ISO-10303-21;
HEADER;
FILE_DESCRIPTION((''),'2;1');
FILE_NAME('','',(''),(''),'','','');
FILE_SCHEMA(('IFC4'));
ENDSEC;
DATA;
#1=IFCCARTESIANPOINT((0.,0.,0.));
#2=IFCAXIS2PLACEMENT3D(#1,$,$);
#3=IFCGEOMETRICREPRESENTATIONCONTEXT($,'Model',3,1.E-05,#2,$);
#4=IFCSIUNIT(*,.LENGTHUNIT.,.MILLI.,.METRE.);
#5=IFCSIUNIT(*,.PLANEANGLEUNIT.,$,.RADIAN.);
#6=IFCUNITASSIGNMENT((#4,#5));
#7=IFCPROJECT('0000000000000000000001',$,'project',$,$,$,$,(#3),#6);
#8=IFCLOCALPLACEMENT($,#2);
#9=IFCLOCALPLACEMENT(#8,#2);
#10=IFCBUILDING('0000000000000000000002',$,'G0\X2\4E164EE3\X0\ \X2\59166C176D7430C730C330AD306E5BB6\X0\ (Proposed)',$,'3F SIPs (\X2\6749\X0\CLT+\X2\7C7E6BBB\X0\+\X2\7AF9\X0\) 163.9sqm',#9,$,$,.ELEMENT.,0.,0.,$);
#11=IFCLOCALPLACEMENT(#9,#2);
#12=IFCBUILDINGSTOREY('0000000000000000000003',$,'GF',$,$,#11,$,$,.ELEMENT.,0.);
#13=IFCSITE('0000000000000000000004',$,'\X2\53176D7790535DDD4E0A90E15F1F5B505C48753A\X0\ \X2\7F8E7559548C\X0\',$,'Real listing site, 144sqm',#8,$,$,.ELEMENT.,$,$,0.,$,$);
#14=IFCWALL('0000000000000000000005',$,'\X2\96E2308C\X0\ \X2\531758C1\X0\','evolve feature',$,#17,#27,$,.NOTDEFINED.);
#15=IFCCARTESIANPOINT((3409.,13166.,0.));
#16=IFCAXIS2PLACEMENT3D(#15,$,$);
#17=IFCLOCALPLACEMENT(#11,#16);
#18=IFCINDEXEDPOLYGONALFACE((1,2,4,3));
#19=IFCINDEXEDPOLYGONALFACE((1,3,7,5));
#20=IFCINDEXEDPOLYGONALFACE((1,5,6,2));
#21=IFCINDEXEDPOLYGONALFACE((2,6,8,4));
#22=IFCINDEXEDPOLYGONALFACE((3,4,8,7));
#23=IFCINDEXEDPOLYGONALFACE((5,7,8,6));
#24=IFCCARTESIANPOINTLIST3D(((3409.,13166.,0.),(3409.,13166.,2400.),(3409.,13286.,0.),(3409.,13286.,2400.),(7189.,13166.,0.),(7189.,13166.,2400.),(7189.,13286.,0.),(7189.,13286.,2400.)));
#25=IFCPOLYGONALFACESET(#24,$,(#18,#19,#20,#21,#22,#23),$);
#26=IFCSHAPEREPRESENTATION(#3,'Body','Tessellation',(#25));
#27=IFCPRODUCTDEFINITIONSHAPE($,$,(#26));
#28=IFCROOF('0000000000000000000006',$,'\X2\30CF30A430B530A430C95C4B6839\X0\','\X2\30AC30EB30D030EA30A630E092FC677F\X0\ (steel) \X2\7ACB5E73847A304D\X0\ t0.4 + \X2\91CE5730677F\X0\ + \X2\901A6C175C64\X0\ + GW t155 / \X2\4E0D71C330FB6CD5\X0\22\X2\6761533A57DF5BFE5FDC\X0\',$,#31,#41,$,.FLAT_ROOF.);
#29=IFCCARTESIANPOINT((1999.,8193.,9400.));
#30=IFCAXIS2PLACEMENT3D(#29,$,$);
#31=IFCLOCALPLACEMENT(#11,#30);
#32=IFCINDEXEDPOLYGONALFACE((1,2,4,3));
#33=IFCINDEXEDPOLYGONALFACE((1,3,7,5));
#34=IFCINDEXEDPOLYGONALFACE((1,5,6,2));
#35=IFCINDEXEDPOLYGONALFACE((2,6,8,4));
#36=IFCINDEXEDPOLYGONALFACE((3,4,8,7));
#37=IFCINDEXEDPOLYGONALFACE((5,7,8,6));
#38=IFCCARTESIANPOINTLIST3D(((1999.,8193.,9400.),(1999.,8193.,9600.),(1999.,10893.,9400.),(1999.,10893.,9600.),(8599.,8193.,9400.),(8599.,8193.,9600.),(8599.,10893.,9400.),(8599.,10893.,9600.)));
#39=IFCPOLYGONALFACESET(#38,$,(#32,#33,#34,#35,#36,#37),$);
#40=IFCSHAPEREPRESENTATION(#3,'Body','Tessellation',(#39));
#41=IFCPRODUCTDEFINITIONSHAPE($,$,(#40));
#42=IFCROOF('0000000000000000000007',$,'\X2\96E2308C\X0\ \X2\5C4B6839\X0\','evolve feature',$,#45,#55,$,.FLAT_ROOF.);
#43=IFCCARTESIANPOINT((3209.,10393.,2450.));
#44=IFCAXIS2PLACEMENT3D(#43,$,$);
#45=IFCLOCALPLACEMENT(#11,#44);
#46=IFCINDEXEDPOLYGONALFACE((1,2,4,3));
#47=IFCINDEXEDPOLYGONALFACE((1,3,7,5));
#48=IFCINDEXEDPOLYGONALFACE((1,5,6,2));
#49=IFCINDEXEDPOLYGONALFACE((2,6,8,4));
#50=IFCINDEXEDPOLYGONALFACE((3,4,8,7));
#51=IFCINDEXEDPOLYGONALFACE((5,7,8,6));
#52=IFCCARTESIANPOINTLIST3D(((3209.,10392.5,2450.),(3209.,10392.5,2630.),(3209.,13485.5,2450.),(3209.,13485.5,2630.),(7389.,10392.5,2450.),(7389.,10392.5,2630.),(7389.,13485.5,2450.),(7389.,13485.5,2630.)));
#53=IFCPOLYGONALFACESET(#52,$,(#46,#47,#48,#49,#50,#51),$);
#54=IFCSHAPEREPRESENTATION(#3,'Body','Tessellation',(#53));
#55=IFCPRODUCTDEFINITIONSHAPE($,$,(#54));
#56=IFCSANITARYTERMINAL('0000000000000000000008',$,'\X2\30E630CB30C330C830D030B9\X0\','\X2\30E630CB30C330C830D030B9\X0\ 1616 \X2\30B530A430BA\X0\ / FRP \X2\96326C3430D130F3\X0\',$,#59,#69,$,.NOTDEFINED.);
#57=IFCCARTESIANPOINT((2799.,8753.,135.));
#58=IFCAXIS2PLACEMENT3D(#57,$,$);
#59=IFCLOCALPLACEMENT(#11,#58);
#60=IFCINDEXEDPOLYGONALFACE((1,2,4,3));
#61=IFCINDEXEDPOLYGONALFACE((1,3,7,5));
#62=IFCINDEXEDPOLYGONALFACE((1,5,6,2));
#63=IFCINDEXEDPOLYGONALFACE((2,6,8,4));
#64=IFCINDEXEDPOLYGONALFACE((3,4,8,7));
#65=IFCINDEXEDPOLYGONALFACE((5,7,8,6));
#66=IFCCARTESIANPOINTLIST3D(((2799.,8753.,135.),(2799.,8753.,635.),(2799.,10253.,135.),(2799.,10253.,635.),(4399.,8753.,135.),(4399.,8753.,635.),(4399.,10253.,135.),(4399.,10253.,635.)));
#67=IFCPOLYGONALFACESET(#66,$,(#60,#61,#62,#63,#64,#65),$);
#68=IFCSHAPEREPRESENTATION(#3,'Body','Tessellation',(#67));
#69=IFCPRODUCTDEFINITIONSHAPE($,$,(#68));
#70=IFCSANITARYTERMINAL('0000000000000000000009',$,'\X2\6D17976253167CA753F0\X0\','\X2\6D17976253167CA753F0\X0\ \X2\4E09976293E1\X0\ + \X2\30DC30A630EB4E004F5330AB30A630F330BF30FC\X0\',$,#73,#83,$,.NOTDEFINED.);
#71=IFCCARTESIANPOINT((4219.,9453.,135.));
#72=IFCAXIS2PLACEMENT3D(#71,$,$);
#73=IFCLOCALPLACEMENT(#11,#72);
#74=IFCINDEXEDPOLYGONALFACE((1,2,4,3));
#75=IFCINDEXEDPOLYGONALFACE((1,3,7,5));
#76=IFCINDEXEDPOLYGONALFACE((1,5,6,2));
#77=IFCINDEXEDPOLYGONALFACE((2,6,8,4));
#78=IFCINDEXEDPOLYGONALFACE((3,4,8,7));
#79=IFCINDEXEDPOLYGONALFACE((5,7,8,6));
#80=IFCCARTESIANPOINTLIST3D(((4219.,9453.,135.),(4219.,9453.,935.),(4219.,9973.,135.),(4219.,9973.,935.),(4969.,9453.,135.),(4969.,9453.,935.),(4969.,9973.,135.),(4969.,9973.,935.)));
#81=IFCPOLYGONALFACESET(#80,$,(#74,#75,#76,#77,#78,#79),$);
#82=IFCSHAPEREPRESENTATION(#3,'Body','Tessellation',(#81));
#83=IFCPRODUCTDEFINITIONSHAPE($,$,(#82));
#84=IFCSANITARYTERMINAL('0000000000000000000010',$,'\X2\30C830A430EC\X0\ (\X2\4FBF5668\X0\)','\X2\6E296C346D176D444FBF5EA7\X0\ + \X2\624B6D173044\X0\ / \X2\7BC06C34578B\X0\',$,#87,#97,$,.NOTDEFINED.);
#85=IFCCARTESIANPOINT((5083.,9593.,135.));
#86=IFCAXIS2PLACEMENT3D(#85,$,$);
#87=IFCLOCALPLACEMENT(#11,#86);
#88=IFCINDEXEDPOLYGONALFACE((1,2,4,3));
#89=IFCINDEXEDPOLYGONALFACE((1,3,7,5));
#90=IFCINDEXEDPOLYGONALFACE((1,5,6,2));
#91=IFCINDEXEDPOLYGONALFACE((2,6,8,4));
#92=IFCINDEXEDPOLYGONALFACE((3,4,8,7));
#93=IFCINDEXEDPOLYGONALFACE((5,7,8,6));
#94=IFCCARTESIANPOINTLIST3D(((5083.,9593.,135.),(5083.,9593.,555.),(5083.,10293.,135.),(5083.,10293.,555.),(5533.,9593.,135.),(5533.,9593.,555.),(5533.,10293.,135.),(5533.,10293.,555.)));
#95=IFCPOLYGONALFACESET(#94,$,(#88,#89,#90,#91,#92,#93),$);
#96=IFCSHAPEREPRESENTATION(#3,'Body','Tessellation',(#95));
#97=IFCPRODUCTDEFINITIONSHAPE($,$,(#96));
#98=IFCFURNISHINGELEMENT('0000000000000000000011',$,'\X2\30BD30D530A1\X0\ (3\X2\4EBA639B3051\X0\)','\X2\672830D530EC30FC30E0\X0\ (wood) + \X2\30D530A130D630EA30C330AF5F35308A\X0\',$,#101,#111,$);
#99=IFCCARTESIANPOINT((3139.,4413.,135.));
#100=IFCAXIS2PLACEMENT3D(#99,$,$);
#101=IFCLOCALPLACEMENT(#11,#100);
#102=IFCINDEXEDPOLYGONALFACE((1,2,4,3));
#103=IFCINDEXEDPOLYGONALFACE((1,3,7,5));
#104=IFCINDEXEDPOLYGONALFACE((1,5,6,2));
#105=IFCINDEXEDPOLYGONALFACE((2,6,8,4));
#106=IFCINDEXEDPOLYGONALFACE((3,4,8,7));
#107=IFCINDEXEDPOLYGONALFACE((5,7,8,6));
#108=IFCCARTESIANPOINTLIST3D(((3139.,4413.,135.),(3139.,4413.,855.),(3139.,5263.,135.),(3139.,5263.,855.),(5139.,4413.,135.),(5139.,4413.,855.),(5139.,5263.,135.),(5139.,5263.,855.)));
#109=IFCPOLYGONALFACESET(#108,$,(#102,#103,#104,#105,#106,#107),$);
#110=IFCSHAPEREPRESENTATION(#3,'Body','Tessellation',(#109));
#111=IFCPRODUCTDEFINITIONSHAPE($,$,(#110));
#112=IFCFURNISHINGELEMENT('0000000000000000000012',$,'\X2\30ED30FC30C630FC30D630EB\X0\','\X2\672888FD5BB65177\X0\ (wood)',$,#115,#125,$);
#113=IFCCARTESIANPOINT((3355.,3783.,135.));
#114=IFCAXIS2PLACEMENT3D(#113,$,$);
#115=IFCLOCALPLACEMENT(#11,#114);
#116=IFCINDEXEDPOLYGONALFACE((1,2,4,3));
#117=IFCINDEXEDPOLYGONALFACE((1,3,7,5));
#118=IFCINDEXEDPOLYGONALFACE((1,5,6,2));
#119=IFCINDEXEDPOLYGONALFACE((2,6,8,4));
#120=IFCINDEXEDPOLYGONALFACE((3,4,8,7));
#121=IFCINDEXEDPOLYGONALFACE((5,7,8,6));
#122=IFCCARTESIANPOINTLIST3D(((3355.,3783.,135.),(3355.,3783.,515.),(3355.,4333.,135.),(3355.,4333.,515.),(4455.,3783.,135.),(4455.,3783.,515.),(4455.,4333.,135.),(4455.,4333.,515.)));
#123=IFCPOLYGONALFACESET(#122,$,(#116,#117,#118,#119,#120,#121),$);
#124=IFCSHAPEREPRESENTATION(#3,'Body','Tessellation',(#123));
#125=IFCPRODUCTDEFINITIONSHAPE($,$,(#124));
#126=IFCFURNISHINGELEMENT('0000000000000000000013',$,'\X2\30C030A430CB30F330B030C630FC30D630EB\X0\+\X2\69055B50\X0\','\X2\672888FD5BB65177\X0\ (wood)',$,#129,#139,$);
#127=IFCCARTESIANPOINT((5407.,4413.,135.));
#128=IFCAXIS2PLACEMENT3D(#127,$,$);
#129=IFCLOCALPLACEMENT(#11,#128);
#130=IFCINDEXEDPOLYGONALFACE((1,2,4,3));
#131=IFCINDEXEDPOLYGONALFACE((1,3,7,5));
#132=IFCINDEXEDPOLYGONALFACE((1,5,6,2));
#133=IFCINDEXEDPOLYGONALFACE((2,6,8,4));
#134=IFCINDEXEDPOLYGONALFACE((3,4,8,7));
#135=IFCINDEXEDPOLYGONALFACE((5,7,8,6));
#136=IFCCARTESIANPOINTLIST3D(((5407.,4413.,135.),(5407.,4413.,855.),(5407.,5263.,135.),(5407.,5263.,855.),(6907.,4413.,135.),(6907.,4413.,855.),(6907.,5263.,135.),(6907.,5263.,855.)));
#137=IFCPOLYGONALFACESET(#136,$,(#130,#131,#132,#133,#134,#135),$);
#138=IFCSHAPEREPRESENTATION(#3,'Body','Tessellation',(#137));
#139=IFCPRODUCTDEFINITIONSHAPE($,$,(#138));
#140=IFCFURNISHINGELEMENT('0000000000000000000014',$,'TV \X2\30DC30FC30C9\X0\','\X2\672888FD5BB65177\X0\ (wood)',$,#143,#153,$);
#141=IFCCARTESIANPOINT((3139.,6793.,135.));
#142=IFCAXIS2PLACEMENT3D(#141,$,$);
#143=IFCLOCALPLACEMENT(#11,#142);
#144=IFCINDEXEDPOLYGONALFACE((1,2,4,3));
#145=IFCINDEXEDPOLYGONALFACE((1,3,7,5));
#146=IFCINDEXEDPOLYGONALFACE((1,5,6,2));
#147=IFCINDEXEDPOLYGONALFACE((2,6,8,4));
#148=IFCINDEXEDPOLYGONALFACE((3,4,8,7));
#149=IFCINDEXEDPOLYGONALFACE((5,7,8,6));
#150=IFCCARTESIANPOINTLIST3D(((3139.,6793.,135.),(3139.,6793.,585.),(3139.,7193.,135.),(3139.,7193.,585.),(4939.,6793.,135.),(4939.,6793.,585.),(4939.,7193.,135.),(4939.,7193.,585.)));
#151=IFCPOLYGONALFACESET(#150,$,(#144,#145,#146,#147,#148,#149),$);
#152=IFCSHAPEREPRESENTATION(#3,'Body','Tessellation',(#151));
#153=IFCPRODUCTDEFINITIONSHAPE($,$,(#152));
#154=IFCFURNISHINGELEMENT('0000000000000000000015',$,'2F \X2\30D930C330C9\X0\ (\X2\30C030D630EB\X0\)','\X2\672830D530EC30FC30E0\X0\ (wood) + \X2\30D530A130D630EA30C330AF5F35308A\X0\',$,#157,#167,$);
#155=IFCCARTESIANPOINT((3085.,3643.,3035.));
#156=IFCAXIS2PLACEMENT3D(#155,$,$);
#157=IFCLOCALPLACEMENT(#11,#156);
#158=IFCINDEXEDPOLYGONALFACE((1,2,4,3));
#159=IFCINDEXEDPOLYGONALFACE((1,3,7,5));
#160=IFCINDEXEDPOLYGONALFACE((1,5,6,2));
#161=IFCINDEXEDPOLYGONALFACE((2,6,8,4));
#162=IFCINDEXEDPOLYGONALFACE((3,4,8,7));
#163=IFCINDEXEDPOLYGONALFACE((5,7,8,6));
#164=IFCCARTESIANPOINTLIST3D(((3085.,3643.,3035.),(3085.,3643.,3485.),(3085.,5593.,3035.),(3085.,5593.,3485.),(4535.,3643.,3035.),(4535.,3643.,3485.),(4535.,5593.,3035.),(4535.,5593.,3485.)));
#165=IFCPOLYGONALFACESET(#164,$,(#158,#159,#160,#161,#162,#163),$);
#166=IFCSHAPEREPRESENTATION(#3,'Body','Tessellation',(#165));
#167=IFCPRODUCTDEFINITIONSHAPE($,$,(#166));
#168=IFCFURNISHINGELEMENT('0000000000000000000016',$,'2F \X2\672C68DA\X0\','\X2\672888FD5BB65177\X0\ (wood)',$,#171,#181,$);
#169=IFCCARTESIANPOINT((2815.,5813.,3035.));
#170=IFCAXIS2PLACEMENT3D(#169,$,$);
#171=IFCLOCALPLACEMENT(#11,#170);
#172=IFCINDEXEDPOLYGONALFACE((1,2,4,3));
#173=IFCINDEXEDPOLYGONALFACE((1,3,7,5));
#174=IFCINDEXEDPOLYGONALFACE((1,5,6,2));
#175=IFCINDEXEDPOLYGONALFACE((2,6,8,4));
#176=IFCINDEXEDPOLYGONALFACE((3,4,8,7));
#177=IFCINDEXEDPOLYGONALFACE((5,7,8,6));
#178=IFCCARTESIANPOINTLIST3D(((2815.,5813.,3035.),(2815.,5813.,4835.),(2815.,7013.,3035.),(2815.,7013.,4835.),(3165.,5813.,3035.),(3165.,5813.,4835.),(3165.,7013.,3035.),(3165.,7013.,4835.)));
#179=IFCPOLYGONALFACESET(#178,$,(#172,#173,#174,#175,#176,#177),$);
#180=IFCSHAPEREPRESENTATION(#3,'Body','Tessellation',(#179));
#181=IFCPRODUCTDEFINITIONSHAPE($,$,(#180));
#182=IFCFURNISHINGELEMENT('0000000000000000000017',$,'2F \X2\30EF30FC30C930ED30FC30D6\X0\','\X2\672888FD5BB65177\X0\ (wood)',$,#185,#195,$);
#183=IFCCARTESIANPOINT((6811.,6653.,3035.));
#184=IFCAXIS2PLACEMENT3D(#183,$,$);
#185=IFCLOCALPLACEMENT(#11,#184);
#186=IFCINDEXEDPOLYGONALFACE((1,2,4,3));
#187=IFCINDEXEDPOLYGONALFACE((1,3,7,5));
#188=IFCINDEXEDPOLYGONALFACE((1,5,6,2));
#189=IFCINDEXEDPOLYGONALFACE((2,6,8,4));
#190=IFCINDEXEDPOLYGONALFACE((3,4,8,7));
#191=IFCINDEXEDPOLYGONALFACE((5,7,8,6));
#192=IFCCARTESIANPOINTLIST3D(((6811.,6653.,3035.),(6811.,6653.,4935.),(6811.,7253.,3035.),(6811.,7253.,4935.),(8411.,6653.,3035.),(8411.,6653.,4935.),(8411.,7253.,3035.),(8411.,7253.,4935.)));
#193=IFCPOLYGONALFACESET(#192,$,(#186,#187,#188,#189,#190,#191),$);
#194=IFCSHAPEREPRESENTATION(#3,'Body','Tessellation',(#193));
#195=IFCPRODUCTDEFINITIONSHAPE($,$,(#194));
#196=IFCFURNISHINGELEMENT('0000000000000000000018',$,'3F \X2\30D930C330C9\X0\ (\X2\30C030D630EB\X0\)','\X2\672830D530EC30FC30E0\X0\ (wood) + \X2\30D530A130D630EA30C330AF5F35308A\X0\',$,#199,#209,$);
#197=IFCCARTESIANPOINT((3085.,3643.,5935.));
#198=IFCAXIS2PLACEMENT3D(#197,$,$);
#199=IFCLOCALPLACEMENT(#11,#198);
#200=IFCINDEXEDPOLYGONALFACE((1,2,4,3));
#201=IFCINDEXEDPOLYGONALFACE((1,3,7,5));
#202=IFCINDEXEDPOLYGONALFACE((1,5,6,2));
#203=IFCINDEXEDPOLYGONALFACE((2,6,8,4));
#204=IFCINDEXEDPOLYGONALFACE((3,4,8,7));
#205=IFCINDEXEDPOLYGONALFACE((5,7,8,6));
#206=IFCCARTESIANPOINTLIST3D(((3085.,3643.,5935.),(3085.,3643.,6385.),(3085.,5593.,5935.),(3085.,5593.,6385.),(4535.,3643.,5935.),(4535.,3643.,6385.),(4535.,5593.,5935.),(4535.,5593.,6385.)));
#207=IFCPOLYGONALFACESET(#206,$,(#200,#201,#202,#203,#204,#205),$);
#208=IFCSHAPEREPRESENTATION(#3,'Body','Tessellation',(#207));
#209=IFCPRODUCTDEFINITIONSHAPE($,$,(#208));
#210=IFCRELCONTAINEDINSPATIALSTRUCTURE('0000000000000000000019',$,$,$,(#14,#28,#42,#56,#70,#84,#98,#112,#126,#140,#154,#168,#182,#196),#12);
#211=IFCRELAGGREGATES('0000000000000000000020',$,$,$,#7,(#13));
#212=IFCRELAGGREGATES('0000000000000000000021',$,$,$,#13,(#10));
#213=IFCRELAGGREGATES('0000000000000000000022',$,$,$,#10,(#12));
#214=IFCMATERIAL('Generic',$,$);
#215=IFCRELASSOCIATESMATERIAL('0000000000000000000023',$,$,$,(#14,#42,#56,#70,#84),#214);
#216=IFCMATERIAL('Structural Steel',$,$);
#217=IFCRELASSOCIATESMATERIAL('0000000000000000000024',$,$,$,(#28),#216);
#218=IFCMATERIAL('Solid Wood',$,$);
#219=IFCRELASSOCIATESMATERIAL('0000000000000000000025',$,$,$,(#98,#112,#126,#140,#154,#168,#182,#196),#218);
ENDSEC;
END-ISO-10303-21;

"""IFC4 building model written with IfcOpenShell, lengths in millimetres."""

from ifc_helpers import new_model, si_unit, frame, frame_2d, origin, place, context, project, spatial, rectangle, extrude, material, element, save


model = new_model("IFC4")

# Units and contexts
model_context = context("Model", 3, precision=1e-05, world=origin())
ifc_project = project(units=[si_unit("LENGTHUNIT", "METRE", prefix="MILLI"), si_unit("PLANEANGLEUNIT", "RADIAN")], contexts=[model_context])

# Site, building, storey
site_placement = place(None, origin())
site = spatial("IfcSite", under=ifc_project, at=site_placement, Name="北海道川上郡弟子屈町 美留和", ObjectType="Real listing site, 144sqm", CompositionType="ELEMENT", RefElevation=0.0)
building_placement = place(site_placement, origin())
building = spatial("IfcBuilding", under=site, at=building_placement, Name="G0世代 外気浴デッキの家 (Proposed)", ObjectType="3F SIPs (杉CLT+籾殻+竹) 163.9sqm", CompositionType="ELEMENT", ElevationOfRefHeight=0.0, ElevationOfTerrain=0.0)
storey_placement = place(building_placement, origin())
storey = spatial("IfcBuildingStorey", under=building, at=storey_placement, Name="GF", CompositionType="ELEMENT", Elevation=0.0)

# Shared definitions
ifc_material_1 = material(Name="Generic")

# Shared definitions
ifc_material_2 = material(Name="Solid Wood")

# Wall
wall_1_placement = place(storey_placement, frame((3409.0, 13166.0, 0.0)))
element("IfcWall", 1, at=wall_1_placement, inside=storey, material=ifc_material_1, Name="離れ 北壁", Description="evolve feature", PredefinedType="NOTDEFINED", context=model_context, shape_type="SweptSolid", body=[
    extrude(rectangle(XDim=3780.0, YDim=120.0, at=frame_2d((1890.0, 60.0))), frame((3409.0, 13166.0, 0.0)), (0.0, 0.0, 1.0), 2400.0),
])

# Roofs
ifc_material_3 = material(Name="Structural Steel")
roof_1_placement = place(storey_placement, frame((1999.0, 8193.0, 9400.0)))
element("IfcRoof", 2, at=roof_1_placement, inside=storey, material=ifc_material_3, Name="ハイサイド屋根", Description="ガルバリウム鋼板 (steel) 立平葺き t0.4 + 野地板 + 通気層 + GW t155 / 不燃・法22条区域対応", PredefinedType="FLAT_ROOF", context=model_context, shape_type="SweptSolid", body=[
    extrude(rectangle(XDim=6600.0, YDim=2700.0, at=frame_2d((3300.0, 1350.0))), frame((1999.0, 8193.0, 9400.0)), (0.0, 0.0, 1.0), 200.0),
])
roof_2_placement = place(storey_placement, frame((3209.0, 10393.0, 2450.0)))
element("IfcRoof", 3, at=roof_2_placement, inside=storey, material=ifc_material_1, Name="離れ 屋根", Description="evolve feature", PredefinedType="FLAT_ROOF", context=model_context, shape_type="SweptSolid", body=[
    extrude(rectangle(XDim=4180.0, YDim=3093.0, at=frame_2d((2090.0, 1546.0))), frame((3209.0, 10393.0, 2450.0)), (0.0, 0.0, 1.0), 180.0),
])

# Sanitary terminals
sanitary_terminal_1_placement = place(storey_placement, frame((2799.0, 8753.0, 135.0)))
element("IfcSanitaryTerminal", 4, at=sanitary_terminal_1_placement, inside=storey, material=ifc_material_1, Name="ユニットバス", Description="ユニットバス 1616 サイズ / FRP 防水パン", PredefinedType="NOTDEFINED", context=model_context, shape_type="SweptSolid", body=[
    extrude(rectangle(XDim=1600.0, YDim=1500.0, at=frame_2d((800.0, 750.0))), frame((2799.0, 8753.0, 135.0)), (0.0, 0.0, 1.0), 500.0),
])
sanitary_terminal_2_placement = place(storey_placement, frame((4219.0, 9453.0, 135.0)))
element("IfcSanitaryTerminal", 5, at=sanitary_terminal_2_placement, inside=storey, material=ifc_material_1, Name="洗面化粧台", Description="洗面化粧台 三面鏡 + ボウル一体カウンター", PredefinedType="NOTDEFINED", context=model_context, shape_type="SweptSolid", body=[
    extrude(rectangle(XDim=750.0, YDim=520.0, at=frame_2d((375.0, 260.0))), frame((4219.0, 9453.0, 135.0)), (0.0, 0.0, 1.0), 800.0),
])
sanitary_terminal_3_placement = place(storey_placement, frame((5083.0, 9593.0, 135.0)))
element("IfcSanitaryTerminal", 6, at=sanitary_terminal_3_placement, inside=storey, material=ifc_material_1, Name="トイレ (便器)", Description="温水洗浄便座 + 手洗い / 節水型", PredefinedType="NOTDEFINED", context=model_context, shape_type="SweptSolid", body=[
    extrude(rectangle(XDim=450.0, YDim=700.0, at=frame_2d((225.0, 350.0))), frame((5083.0, 9593.0, 135.0)), (0.0, 0.0, 1.0), 420.0),
])

# Furnishing elements
furnishing_1_placement = place(storey_placement, frame((3139.0, 4413.0, 135.0)))
element("IfcFurnishingElement", 7, at=furnishing_1_placement, inside=storey, material=ifc_material_2, Name="ソファ (3人掛け)", Description="木フレーム (wood) + ファブリック張り", context=model_context, shape_type="SweptSolid", body=[
    extrude(rectangle(XDim=2000.0, YDim=850.0, at=frame_2d((1000.0, 425.0))), frame((3139.0, 4413.0, 135.0)), (0.0, 0.0, 1.0), 720.0),
])
furnishing_2_placement = place(storey_placement, frame((3355.0, 3783.0, 135.0)))
element("IfcFurnishingElement", 8, at=furnishing_2_placement, inside=storey, material=ifc_material_2, Name="ローテーブル", Description="木製家具 (wood)", context=model_context, shape_type="SweptSolid", body=[
    extrude(rectangle(XDim=1100.0, YDim=550.0, at=frame_2d((550.0, 275.0))), frame((3355.0, 3783.0, 135.0)), (0.0, 0.0, 1.0), 380.0),
])
furnishing_3_placement = place(storey_placement, frame((5407.0, 4413.0, 135.0)))
element("IfcFurnishingElement", 9, at=furnishing_3_placement, inside=storey, material=ifc_material_2, Name="ダイニングテーブル+椅子", Description="木製家具 (wood)", context=model_context, shape_type="SweptSolid", body=[
    extrude(rectangle(XDim=1500.0, YDim=850.0, at=frame_2d((750.0, 425.0))), frame((5407.0, 4413.0, 135.0)), (0.0, 0.0, 1.0), 720.0),
])
furnishing_4_placement = place(storey_placement, frame((3139.0, 6793.0, 135.0)))
element("IfcFurnishingElement", 10, at=furnishing_4_placement, inside=storey, material=ifc_material_2, Name="TV ボード", Description="木製家具 (wood)", context=model_context, shape_type="SweptSolid", body=[
    extrude(rectangle(XDim=1800.0, YDim=400.0, at=frame_2d((900.0, 200.0))), frame((3139.0, 6793.0, 135.0)), (0.0, 0.0, 1.0), 450.0),
])
furnishing_5_placement = place(storey_placement, frame((3085.0, 3643.0, 3035.0)))
element("IfcFurnishingElement", 11, at=furnishing_5_placement, inside=storey, material=ifc_material_2, Name="2F ベッド (ダブル)", Description="木フレーム (wood) + ファブリック張り", context=model_context, shape_type="SweptSolid", body=[
    extrude(rectangle(XDim=1450.0, YDim=1950.0, at=frame_2d((725.0, 975.0))), frame((3085.0, 3643.0, 3035.0)), (0.0, 0.0, 1.0), 450.0),
])
furnishing_6_placement = place(storey_placement, frame((2815.0, 5813.0, 3035.0)))
element("IfcFurnishingElement", 12, at=furnishing_6_placement, inside=storey, material=ifc_material_2, Name="2F 本棚", Description="木製家具 (wood)", context=model_context, shape_type="SweptSolid", body=[
    extrude(rectangle(XDim=350.0, YDim=1200.0, at=frame_2d((175.0, 600.0))), frame((2815.0, 5813.0, 3035.0)), (0.0, 0.0, 1.0), 1800.0),
])
furnishing_7_placement = place(storey_placement, frame((6811.0, 6653.0, 3035.0)))
element("IfcFurnishingElement", 13, at=furnishing_7_placement, inside=storey, material=ifc_material_2, Name="2F ワードローブ", Description="木製家具 (wood)", context=model_context, shape_type="SweptSolid", body=[
    extrude(rectangle(XDim=1600.0, YDim=600.0, at=frame_2d((800.0, 300.0))), frame((6811.0, 6653.0, 3035.0)), (0.0, 0.0, 1.0), 1900.0),
])
furnishing_8_placement = place(storey_placement, frame((3085.0, 3643.0, 5935.0)))
element("IfcFurnishingElement", 14, at=furnishing_8_placement, inside=storey, material=ifc_material_2, Name="3F ベッド (ダブル)", Description="木フレーム (wood) + ファブリック張り", context=model_context, shape_type="SweptSolid", body=[
    extrude(rectangle(XDim=1450.0, YDim=1950.0, at=frame_2d((725.0, 975.0))), frame((3085.0, 3643.0, 5935.0)), (0.0, 0.0, 1.0), 450.0),
])

save(model, "model.ifc")
